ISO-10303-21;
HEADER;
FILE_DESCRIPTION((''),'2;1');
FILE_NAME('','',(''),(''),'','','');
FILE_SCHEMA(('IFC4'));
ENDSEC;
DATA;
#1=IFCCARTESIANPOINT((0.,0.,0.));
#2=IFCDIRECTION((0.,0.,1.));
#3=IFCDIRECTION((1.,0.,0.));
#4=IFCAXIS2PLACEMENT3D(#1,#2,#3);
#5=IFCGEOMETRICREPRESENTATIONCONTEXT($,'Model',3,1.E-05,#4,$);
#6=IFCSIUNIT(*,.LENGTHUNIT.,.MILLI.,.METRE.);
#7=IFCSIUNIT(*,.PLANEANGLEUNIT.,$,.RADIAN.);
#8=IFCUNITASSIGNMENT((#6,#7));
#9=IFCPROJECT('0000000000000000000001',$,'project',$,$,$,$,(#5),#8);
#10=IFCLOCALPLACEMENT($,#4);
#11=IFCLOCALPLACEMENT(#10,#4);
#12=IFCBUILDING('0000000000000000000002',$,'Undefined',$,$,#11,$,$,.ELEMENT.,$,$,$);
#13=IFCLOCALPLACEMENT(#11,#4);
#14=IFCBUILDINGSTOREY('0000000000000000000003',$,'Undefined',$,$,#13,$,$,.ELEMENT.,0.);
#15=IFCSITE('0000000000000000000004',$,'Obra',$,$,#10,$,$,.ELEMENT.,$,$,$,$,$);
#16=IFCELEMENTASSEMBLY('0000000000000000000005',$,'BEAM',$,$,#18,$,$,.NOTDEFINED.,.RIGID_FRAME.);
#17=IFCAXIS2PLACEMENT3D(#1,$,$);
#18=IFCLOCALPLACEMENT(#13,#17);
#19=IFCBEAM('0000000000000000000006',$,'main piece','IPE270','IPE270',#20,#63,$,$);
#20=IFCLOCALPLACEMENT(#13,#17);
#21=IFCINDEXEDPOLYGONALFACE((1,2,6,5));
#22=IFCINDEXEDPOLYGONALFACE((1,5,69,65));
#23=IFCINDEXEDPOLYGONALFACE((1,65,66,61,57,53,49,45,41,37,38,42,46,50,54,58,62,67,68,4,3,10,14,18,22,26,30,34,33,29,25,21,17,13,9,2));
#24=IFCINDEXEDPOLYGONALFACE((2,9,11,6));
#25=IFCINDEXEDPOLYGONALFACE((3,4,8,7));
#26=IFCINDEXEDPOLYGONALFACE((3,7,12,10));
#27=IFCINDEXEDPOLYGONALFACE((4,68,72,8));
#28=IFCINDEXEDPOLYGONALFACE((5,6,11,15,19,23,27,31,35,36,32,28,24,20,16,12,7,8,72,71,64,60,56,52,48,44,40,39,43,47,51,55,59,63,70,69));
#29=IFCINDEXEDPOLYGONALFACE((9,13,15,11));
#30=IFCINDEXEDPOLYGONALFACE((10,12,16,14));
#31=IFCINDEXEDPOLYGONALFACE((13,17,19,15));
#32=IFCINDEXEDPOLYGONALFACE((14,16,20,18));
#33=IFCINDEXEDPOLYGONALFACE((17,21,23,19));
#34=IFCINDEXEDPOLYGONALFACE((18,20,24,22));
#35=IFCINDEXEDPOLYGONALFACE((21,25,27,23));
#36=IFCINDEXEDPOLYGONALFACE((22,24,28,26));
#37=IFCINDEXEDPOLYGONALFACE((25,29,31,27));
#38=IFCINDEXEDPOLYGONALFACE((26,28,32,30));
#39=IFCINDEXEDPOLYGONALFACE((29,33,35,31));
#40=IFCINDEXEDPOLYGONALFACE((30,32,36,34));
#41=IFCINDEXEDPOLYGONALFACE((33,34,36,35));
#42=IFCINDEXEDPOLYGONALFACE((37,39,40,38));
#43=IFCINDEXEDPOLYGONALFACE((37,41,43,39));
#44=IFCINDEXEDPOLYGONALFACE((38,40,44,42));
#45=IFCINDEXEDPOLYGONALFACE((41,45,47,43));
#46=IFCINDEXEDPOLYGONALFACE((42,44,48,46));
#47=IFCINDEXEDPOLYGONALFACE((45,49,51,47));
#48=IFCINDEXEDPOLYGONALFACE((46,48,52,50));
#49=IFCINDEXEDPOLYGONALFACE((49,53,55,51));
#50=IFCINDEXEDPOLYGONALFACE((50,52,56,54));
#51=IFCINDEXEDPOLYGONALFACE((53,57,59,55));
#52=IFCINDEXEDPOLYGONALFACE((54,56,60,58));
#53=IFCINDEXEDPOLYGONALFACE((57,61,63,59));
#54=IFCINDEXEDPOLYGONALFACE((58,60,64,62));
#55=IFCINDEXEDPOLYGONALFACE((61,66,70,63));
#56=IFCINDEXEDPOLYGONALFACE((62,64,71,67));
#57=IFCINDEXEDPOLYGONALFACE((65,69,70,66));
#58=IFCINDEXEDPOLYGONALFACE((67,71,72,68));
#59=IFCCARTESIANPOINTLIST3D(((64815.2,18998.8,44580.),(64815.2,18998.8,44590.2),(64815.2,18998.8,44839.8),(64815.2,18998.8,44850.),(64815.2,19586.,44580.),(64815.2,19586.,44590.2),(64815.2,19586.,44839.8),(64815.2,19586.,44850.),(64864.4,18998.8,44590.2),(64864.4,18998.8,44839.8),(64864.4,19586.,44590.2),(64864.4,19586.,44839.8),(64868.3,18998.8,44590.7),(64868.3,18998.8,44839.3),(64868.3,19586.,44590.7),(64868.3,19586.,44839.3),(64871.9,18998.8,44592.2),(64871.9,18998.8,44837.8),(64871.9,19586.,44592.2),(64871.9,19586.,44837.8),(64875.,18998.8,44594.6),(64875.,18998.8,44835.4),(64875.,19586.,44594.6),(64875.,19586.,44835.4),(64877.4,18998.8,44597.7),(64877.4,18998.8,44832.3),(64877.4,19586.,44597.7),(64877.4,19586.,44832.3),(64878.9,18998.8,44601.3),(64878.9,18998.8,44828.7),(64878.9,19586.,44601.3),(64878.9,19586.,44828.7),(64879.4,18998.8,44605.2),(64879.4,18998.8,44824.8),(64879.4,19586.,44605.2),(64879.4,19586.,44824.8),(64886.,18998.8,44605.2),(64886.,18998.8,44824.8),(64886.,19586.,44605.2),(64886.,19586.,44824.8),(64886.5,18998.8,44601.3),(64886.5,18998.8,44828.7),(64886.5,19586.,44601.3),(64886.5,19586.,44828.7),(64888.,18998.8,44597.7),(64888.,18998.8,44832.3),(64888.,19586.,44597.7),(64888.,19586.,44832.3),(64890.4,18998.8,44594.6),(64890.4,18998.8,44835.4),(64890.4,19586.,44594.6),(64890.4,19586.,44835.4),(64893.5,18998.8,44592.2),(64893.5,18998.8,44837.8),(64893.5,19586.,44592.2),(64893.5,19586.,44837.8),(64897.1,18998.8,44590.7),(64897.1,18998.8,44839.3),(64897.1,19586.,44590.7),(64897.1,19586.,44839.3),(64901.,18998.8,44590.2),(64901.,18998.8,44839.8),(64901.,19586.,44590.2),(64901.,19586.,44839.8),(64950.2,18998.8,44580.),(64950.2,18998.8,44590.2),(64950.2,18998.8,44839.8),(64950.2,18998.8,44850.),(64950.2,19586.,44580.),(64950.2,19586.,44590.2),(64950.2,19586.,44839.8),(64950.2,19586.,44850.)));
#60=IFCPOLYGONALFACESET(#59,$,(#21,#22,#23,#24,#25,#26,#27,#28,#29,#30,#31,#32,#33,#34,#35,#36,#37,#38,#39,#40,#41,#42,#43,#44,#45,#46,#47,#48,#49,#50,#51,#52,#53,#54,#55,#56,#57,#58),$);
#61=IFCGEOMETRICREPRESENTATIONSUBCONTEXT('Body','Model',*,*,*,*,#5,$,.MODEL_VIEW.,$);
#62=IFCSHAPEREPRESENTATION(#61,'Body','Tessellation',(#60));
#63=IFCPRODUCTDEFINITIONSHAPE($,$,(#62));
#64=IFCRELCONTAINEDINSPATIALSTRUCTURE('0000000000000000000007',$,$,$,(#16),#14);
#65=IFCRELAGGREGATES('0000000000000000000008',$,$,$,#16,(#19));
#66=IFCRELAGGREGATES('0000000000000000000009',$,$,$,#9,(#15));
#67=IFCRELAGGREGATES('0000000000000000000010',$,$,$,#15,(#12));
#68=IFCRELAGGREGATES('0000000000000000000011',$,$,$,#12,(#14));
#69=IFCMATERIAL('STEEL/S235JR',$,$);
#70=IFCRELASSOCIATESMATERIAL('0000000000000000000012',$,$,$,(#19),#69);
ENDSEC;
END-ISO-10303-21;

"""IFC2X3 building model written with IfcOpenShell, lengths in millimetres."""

from ifc_helpers import new_model, si_unit, frame, origin_with_axes, origin_2d_with_axis, place, context, subcontext, project, spatial, i_section, extrude, material, element, aggregate, save


model = new_model("IFC2X3")

# Units and contexts
model_context = context("Model", 3, precision=1e-05, world=origin_with_axes())
body_context = subcontext(model_context, "Body", "Model", "MODEL_VIEW")
ifc_project = project(units=[si_unit("LENGTHUNIT", "METRE", prefix="MILLI"), si_unit("PLANEANGLEUNIT", "RADIAN")], contexts=[model_context])

# Site, building, storey
site_placement = place(None, origin_with_axes())
site = spatial("IfcSite", under=ifc_project, at=site_placement, Name="Obra", CompositionType="ELEMENT")
building_placement = place(site_placement, origin_with_axes())
building = spatial("IfcBuilding", under=site, at=building_placement, Name="Undefined", CompositionType="ELEMENT")
storey_placement = place(building_placement, origin_with_axes())
storey = spatial("IfcBuildingStorey", under=building, at=storey_placement, Name="Undefined", CompositionType="ELEMENT", Elevation=0.0)

# Shared definitions
ifc_material_1 = material(Name="STEEL/S235JR")

# Element assembly, beam
assembly_1_placement = place(storey_placement, origin_with_axes())
assembly_1 = element("IfcElementAssembly", 1, at=assembly_1_placement, inside=storey, Name="BEAM", AssemblyPlace="NOTDEFINED", PredefinedType="RIGID_FRAME")
beam_1_placement = place(assembly_1_placement, frame((64882.7, 18998.8, 44715.0), z_axis=(0.0, 0.0, 1.0), x_axis=(-0.000002, 1.0, 0.0)))
beam_1 = element("IfcBeam", 2, at=beam_1_placement, material=ifc_material_1, Name="main piece", Description="IPE270", ObjectType="IPE270", context=body_context, shape_type="SweptSolid", body=[
    extrude(i_section(OverallWidth=135.0, OverallDepth=270.0, WebThickness=6.6, FlangeThickness=10.2, FilletRadius=15.0, at=origin_2d_with_axis()), frame((587.2, 0.0, 0.0), z_axis=(-1.0, 0.0, 0.0), x_axis=(0.0, -1.0, 0.0)), (0.0, 0.0, 1.0), 587.2),
])
aggregate(assembly_1, [beam_1])

save(model, "model.ifc")
